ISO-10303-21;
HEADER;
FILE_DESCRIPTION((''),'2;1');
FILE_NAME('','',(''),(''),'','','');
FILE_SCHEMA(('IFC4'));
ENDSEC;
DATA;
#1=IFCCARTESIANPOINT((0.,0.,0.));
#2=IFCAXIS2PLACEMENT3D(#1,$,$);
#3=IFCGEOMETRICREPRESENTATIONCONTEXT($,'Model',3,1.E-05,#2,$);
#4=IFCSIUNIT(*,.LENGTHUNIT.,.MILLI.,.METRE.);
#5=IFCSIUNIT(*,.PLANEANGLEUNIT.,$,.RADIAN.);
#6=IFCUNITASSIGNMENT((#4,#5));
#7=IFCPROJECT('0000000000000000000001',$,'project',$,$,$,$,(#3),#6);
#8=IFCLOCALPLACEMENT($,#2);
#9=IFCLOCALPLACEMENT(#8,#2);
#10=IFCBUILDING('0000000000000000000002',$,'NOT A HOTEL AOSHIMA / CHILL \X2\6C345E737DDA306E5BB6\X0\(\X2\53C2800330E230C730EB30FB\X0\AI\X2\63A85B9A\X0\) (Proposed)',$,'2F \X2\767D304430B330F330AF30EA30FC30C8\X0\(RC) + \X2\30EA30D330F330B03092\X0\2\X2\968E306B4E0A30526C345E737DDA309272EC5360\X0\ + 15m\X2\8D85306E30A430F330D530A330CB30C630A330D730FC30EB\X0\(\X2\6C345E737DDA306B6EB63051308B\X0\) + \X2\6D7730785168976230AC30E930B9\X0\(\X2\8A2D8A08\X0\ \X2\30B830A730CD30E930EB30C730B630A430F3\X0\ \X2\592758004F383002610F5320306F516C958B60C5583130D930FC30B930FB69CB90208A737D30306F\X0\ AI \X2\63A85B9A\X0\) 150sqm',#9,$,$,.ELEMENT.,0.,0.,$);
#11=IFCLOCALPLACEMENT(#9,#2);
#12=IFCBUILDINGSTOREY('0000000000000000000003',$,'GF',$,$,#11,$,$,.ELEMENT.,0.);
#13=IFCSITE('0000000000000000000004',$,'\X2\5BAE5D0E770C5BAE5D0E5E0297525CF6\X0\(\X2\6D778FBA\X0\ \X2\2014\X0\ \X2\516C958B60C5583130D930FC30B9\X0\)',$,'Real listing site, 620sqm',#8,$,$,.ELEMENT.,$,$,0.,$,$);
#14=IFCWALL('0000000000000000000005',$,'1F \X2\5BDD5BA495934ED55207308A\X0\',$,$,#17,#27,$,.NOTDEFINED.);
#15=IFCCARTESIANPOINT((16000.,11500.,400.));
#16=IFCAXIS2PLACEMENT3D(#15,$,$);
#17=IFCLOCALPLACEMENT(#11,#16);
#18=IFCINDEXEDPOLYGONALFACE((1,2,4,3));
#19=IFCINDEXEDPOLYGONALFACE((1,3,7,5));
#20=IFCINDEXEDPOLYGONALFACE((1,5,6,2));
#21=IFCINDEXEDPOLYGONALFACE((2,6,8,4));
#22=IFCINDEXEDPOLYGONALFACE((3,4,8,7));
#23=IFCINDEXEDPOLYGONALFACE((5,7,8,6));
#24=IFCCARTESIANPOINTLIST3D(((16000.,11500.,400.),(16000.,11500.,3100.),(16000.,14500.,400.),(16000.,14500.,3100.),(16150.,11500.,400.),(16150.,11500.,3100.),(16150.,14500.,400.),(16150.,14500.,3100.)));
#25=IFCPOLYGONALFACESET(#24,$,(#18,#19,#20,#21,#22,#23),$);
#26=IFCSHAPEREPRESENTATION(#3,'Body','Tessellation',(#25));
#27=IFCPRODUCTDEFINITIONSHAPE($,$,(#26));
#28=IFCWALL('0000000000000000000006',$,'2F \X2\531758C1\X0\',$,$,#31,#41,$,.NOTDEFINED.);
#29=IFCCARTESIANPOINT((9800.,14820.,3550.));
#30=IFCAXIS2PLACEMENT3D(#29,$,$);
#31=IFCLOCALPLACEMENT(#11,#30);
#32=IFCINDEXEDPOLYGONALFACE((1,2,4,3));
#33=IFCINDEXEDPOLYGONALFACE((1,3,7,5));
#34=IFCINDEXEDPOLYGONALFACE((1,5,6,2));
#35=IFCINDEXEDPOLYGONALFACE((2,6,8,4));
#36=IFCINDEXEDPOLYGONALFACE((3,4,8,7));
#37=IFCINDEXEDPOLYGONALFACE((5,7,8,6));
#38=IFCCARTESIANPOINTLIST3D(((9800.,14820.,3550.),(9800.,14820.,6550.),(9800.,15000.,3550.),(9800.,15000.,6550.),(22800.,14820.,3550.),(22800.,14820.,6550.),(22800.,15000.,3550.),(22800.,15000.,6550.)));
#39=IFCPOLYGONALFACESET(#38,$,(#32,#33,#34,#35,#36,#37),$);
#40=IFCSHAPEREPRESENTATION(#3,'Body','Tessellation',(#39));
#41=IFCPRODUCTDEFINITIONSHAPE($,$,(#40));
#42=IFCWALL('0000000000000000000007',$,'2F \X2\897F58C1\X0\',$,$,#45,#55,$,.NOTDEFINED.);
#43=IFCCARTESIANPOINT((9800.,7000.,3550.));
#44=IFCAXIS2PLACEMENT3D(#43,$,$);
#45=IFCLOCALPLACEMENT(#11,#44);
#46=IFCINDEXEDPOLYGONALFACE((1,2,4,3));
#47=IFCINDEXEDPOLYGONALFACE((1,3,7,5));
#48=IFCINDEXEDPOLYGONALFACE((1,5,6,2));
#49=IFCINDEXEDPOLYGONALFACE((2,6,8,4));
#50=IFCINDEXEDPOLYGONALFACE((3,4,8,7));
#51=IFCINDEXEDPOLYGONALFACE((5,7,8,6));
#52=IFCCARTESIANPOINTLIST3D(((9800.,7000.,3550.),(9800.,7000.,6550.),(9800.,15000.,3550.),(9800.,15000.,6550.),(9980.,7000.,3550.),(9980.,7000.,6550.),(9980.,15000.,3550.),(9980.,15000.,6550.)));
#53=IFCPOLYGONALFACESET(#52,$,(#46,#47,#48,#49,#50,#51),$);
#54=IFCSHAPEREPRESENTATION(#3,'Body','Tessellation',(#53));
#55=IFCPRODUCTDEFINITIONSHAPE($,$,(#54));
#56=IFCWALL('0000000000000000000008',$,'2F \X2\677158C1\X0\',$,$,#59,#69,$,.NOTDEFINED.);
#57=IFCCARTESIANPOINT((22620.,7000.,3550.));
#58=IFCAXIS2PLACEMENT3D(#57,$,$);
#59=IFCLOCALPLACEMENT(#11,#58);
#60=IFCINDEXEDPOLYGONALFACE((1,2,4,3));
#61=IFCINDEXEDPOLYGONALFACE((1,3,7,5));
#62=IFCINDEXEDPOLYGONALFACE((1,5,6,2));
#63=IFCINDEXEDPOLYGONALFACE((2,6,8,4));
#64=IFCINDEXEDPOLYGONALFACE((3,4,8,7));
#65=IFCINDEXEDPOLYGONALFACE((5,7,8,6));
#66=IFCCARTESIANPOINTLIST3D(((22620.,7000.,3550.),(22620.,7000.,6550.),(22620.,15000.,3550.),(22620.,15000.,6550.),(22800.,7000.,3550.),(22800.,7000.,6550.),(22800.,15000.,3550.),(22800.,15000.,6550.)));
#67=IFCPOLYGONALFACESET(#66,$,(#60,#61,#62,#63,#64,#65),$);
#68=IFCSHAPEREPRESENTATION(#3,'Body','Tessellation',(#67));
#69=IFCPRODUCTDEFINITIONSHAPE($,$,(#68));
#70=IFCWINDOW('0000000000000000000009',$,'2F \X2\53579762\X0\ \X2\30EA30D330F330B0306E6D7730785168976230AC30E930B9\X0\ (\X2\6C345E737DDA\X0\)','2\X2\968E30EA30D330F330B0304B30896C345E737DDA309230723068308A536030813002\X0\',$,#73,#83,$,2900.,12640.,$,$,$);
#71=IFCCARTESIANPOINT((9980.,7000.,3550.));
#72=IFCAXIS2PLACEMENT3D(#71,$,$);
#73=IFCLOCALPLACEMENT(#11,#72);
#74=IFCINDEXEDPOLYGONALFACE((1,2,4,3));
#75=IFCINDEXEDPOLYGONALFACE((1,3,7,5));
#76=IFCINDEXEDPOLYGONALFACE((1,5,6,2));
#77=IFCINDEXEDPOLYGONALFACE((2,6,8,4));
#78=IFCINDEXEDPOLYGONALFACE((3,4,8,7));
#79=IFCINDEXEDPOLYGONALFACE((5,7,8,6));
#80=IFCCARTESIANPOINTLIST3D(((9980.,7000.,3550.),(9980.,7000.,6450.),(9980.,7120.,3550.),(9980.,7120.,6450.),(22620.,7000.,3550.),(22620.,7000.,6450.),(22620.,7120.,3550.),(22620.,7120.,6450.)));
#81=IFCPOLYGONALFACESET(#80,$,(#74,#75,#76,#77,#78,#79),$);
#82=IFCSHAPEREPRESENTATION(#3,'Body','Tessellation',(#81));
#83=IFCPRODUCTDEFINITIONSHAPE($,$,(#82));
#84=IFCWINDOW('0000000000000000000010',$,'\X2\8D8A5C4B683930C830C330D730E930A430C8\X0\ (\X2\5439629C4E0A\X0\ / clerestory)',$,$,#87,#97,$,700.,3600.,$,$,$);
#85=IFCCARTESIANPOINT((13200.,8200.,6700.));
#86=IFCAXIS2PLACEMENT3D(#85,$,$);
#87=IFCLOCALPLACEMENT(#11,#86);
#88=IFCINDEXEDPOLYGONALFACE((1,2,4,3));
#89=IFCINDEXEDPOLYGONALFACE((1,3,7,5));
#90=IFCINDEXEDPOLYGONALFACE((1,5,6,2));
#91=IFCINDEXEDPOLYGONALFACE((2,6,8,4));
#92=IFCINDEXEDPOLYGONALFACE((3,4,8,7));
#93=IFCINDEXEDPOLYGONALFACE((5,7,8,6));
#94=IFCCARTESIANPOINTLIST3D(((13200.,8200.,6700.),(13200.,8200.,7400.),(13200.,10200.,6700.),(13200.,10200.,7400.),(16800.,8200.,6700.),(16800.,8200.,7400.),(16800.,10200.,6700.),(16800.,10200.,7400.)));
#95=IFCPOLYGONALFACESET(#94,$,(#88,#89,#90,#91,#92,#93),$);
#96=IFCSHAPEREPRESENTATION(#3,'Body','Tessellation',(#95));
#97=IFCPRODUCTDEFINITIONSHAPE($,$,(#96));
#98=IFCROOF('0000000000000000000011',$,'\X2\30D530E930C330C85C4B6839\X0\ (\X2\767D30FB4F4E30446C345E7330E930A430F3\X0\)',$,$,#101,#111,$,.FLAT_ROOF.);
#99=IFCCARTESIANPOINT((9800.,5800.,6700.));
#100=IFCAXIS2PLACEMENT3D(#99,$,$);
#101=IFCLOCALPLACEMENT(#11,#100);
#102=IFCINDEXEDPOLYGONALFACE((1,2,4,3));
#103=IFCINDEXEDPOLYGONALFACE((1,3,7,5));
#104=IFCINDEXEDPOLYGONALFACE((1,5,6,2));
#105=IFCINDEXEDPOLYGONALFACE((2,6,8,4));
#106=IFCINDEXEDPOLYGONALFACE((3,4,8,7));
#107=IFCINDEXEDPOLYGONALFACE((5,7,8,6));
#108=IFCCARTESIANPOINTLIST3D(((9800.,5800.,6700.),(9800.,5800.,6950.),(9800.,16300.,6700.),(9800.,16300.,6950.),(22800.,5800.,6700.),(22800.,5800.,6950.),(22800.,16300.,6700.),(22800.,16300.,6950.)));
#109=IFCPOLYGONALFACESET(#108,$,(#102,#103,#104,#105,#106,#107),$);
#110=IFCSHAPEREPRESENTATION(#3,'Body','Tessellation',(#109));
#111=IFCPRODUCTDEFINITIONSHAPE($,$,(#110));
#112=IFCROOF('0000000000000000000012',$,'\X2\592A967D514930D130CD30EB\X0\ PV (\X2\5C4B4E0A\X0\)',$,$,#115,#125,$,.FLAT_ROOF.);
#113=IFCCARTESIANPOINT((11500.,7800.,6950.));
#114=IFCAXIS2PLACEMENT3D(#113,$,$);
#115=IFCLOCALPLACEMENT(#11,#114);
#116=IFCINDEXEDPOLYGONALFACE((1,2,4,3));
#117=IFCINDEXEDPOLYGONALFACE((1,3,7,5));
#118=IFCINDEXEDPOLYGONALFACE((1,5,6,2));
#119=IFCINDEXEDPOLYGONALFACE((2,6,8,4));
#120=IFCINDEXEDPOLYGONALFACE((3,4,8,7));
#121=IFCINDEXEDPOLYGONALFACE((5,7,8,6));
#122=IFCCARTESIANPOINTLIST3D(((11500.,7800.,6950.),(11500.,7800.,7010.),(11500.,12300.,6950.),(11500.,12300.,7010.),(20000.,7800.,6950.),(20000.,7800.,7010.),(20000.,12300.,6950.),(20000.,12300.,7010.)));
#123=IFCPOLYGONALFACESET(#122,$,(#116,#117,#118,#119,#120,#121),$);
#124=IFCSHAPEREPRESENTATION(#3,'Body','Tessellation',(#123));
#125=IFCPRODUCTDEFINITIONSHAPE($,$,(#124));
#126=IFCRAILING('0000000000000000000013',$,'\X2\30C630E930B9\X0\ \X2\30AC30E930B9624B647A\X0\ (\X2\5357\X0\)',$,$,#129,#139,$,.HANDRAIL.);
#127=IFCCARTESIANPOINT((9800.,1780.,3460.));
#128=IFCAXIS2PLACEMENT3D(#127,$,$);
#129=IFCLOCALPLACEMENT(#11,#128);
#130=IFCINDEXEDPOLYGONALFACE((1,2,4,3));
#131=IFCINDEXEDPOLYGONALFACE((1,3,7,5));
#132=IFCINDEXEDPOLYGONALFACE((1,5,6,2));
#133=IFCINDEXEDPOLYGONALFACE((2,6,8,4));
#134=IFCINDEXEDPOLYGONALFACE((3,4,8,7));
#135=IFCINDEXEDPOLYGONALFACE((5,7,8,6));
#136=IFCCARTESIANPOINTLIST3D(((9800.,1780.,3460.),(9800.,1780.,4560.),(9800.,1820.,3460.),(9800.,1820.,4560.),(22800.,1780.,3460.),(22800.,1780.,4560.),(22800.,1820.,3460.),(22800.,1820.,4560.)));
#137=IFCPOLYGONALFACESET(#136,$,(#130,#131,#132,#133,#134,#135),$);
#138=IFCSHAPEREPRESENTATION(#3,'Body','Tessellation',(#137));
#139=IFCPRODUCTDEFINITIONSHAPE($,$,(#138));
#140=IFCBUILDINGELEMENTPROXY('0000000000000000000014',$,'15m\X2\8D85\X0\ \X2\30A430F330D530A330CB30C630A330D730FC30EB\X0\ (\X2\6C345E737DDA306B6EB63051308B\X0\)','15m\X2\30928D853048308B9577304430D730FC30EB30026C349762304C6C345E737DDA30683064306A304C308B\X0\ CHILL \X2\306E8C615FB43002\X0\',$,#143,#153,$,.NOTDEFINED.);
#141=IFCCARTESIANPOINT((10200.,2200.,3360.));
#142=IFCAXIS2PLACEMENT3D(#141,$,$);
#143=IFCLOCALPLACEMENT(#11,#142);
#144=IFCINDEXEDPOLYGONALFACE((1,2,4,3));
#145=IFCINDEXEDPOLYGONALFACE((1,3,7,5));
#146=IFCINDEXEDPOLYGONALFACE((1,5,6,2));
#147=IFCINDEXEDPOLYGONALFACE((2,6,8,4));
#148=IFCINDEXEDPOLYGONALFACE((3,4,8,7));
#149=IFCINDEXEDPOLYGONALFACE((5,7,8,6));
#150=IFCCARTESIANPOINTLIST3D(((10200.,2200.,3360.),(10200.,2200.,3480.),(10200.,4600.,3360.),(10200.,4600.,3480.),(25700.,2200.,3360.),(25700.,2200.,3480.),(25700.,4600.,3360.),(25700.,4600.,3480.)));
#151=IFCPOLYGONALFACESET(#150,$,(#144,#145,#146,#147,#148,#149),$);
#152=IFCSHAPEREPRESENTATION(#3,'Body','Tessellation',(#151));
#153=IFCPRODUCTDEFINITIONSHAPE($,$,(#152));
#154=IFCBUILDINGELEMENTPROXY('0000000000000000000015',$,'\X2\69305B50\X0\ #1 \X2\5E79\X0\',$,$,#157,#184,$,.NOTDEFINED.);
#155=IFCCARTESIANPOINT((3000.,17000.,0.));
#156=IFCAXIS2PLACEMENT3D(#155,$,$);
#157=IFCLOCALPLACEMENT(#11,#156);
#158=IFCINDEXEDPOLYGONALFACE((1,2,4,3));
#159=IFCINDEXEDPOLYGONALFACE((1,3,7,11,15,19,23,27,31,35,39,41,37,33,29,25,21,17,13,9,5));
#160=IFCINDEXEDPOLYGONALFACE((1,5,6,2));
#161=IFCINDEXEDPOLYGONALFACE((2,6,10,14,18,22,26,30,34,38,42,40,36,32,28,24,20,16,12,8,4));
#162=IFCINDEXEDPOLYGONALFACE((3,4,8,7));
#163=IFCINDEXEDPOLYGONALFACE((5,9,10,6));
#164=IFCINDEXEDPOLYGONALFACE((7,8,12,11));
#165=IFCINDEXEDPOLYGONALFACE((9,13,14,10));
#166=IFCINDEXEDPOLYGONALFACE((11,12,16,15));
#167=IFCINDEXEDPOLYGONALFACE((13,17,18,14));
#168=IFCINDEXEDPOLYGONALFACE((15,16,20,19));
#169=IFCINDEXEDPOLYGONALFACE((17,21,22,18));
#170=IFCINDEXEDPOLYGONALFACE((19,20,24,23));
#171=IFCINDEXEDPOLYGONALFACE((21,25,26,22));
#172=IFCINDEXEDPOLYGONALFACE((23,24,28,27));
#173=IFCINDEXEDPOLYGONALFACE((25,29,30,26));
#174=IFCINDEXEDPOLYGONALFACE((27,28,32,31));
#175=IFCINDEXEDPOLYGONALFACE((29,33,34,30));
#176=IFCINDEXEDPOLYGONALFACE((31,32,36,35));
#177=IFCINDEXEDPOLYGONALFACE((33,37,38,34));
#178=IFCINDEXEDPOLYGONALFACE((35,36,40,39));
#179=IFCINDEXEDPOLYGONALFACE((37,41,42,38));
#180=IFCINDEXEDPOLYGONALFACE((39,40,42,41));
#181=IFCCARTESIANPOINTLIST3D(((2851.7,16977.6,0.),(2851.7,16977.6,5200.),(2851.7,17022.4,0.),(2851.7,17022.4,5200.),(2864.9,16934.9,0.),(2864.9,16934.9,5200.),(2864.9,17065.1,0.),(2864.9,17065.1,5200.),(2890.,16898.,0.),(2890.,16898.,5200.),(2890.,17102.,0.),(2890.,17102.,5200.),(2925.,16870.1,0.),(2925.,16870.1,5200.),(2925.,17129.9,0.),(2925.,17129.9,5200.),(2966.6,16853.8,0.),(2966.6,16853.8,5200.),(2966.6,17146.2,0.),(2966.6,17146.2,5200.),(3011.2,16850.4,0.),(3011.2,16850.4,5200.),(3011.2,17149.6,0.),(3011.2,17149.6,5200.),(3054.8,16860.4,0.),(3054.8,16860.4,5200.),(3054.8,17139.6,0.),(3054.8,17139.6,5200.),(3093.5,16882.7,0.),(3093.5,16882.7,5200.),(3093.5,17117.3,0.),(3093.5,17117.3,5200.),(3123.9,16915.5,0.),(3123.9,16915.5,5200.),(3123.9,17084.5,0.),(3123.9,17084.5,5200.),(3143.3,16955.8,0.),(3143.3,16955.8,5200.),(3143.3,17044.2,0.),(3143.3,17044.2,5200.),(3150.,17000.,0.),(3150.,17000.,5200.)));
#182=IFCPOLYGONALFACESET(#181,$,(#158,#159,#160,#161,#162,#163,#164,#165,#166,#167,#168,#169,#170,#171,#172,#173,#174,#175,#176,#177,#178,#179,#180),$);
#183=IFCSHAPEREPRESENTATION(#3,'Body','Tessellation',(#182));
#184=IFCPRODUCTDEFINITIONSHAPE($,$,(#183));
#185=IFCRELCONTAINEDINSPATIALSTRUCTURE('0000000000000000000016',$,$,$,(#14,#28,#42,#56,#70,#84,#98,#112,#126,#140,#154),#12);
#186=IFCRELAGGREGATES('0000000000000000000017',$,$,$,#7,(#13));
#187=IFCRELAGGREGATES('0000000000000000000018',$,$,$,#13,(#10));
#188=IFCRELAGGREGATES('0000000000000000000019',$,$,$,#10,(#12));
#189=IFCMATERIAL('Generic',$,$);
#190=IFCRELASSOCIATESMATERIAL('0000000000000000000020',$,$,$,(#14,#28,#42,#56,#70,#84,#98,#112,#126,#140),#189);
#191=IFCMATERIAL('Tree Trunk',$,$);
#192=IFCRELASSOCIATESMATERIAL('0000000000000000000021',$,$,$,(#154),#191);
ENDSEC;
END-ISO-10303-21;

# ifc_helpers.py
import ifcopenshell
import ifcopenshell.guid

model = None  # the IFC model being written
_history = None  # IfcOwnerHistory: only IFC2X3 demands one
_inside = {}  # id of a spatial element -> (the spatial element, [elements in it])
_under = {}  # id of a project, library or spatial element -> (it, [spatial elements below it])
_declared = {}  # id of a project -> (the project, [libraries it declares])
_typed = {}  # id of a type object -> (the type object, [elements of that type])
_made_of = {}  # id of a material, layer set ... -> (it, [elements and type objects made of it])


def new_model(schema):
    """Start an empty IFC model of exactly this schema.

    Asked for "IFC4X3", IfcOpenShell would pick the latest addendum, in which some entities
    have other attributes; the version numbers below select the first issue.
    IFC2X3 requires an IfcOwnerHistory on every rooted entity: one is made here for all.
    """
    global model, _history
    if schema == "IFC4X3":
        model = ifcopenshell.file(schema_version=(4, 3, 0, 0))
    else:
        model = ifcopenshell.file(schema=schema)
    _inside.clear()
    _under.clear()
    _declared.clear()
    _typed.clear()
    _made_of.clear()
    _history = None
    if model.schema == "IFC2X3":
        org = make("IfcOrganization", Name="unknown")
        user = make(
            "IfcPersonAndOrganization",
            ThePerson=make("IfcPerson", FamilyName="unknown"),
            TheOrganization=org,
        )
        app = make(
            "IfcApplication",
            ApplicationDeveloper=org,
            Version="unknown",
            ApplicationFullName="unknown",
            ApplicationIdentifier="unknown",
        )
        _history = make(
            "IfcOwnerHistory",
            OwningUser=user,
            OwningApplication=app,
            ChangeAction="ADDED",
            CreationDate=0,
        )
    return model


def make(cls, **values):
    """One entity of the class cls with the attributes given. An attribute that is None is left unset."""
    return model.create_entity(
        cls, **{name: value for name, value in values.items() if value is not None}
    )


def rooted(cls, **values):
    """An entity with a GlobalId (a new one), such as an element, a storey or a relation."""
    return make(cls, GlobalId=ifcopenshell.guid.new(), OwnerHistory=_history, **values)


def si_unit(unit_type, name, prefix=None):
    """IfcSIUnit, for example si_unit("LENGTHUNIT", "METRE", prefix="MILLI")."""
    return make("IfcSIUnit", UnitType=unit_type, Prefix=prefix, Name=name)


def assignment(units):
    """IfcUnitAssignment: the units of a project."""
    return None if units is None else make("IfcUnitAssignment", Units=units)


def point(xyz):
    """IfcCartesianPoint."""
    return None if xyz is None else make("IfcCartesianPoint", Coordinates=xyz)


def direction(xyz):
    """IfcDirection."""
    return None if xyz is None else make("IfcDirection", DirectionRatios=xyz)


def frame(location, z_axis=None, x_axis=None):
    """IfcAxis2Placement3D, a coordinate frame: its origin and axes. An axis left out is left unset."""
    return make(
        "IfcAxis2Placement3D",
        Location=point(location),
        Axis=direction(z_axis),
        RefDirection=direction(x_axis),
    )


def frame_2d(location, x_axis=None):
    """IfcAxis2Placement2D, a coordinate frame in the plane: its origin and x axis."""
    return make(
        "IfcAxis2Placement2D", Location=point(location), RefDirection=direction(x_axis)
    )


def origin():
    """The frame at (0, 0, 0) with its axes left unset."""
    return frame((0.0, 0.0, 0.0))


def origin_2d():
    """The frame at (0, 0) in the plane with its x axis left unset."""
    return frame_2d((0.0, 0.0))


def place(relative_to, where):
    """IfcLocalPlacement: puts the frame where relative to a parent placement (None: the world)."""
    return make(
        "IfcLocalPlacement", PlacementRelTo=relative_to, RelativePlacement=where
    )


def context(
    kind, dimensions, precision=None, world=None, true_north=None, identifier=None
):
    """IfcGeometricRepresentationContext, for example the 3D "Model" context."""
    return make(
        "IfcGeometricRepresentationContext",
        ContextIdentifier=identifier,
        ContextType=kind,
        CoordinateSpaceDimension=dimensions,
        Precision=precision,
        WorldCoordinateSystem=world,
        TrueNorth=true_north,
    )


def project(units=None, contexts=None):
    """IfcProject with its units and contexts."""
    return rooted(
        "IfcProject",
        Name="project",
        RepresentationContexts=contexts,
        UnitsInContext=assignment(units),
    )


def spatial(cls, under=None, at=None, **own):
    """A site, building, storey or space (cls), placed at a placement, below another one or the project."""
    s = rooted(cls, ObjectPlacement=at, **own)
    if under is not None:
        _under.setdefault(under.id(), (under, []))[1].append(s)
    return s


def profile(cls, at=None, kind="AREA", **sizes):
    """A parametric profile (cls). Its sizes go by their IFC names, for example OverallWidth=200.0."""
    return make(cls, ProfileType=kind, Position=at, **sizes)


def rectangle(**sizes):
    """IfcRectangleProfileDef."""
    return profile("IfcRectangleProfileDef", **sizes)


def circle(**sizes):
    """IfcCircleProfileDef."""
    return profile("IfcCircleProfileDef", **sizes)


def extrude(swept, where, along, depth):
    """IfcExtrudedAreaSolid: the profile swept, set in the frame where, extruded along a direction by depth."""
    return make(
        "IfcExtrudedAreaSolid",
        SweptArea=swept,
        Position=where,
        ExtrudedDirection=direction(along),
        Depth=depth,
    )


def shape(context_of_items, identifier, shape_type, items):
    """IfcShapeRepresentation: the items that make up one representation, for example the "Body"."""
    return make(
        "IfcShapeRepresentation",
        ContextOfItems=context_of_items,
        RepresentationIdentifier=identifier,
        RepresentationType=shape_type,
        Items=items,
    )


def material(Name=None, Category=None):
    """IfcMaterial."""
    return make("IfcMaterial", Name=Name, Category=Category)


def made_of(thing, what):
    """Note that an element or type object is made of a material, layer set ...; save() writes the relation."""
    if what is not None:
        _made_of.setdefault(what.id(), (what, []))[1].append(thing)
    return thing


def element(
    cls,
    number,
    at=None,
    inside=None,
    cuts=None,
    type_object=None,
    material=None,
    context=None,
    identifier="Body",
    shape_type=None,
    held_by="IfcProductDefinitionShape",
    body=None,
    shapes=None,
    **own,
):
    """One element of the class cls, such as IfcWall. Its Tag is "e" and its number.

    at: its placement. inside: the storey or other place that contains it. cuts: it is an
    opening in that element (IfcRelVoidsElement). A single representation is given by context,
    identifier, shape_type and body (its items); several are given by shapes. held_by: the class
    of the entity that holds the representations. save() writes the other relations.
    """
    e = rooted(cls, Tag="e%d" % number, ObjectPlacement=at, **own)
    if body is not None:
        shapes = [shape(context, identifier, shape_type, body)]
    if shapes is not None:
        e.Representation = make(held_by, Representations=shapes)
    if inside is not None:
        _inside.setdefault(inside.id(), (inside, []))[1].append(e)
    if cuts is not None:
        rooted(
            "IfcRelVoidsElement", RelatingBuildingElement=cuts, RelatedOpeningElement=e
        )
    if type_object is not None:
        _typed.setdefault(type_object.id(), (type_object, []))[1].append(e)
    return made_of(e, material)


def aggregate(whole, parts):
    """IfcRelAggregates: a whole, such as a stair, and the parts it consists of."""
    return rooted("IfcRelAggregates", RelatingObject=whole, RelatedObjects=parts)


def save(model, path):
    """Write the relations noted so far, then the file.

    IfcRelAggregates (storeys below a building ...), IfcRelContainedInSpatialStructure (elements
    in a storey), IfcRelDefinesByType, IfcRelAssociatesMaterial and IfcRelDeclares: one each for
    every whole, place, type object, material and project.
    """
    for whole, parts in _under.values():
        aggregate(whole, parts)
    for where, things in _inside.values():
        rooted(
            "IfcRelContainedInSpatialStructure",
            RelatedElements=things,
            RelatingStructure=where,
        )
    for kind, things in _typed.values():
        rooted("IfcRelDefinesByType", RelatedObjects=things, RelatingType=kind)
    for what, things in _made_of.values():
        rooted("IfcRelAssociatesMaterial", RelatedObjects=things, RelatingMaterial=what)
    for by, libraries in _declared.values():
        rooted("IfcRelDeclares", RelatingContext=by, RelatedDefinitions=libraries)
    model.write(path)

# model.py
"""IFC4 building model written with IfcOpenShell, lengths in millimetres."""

from ifc_helpers import new_model, si_unit, frame, frame_2d, origin, origin_2d, place, context, project, spatial, rectangle, circle, extrude, material, element, save


model = new_model("IFC4")

# Units and contexts
model_context = context("Model", 3, precision=1e-05, world=origin())
ifc_project = project(units=[si_unit("LENGTHUNIT", "METRE", prefix="MILLI"), si_unit("PLANEANGLEUNIT", "RADIAN")], contexts=[model_context])

# Site, building, storey
site_placement = place(None, origin())
site = spatial("IfcSite", under=ifc_project, at=site_placement, Name="宮崎県宮崎市青島(海辺 — 公開情報ベース)", ObjectType="Real listing site, 620sqm", CompositionType="ELEMENT", RefElevation=0.0)
building_placement = place(site_placement, origin())
building = spatial("IfcBuilding", under=site, at=building_placement, Name="NOT A HOTEL AOSHIMA / CHILL 水平線の家(参考モデル・AI推定) (Proposed)", ObjectType="2F 白いコンクリート(RC) + リビングを2階に上げ水平線を独占 + 15m超のインフィニティプール(水平線に溶ける) + 海へ全面ガラス(設計 ジェネラルデザイン 大堀伸。意匠は公開情報ベース・構造詳細は AI 推定) 150sqm", CompositionType="ELEMENT", ElevationOfRefHeight=0.0, ElevationOfTerrain=0.0)
storey_placement = place(building_placement, origin())
storey = spatial("IfcBuildingStorey", under=building, at=storey_placement, Name="GF", CompositionType="ELEMENT", Elevation=0.0)

# Shared definitions
ifc_material_1 = material(Name="Generic")

# Walls
wall_1_placement = place(storey_placement, frame((16000.0, 11500.0, 400.0)))
element("IfcWall", 1, at=wall_1_placement, inside=storey, material=ifc_material_1, Name="1F 寝室間仕切り", PredefinedType="NOTDEFINED", context=model_context, shape_type="SweptSolid", body=[
    extrude(rectangle(XDim=150.0, YDim=3000.0, at=frame_2d((75.0, 1500.0))), frame((16000.0, 11500.0, 400.0)), (0.0, 0.0, 1.0), 2700.0),
])
wall_2_placement = place(storey_placement, frame((9800.0, 14820.0, 3550.0)))
element("IfcWall", 2, at=wall_2_placement, inside=storey, material=ifc_material_1, Name="2F 北壁", PredefinedType="NOTDEFINED", context=model_context, shape_type="SweptSolid", body=[
    extrude(rectangle(XDim=13000.0, YDim=180.0, at=frame_2d((6500.0, 90.0))), frame((9800.0, 14820.0, 3550.0)), (0.0, 0.0, 1.0), 3000.0),
])
wall_3_placement = place(storey_placement, frame((9800.0, 7000.0, 3550.0)))
element("IfcWall", 3, at=wall_3_placement, inside=storey, material=ifc_material_1, Name="2F 西壁", PredefinedType="NOTDEFINED", context=model_context, shape_type="SweptSolid", body=[
    extrude(rectangle(XDim=180.0, YDim=8000.0, at=frame_2d((90.0, 4000.0))), frame((9800.0, 7000.0, 3550.0)), (0.0, 0.0, 1.0), 3000.0),
])
wall_4_placement = place(storey_placement, frame((22620.0, 7000.0, 3550.0)))
element("IfcWall", 4, at=wall_4_placement, inside=storey, material=ifc_material_1, Name="2F 東壁", PredefinedType="NOTDEFINED", context=model_context, shape_type="SweptSolid", body=[
    extrude(rectangle(XDim=180.0, YDim=8000.0, at=frame_2d((90.0, 4000.0))), frame((22620.0, 7000.0, 3550.0)), (0.0, 0.0, 1.0), 3000.0),
])

# Windows
window_1_placement = place(storey_placement, frame((9980.0, 7000.0, 3550.0)))
element("IfcWindow", 5, at=window_1_placement, inside=storey, material=ifc_material_1, Name="2F 南面 リビングの海へ全面ガラス (水平線)", Description="2階リビングから水平線をひとり占め。", OverallHeight=2900.0, OverallWidth=12640.0, context=model_context, shape_type="SweptSolid", body=[
    extrude(rectangle(XDim=12640.0, YDim=120.0, at=frame_2d((6320.0, 60.0))), frame((9980.0, 7000.0, 3550.0)), (0.0, 0.0, 1.0), 2900.0),
])
window_2_placement = place(storey_placement, frame((13200.0, 8200.0, 6700.0)))
element("IfcWindow", 6, at=window_2_placement, inside=storey, material=ifc_material_1, Name="越屋根トップライト (吹抜上 / clerestory)", OverallHeight=700.0, OverallWidth=3600.0, context=model_context, shape_type="SweptSolid", body=[
    extrude(rectangle(XDim=3600.0, YDim=2000.0, at=frame_2d((1800.0, 1000.0))), frame((13200.0, 8200.0, 6700.0)), (0.0, 0.0, 1.0), 700.0),
])

# Roofs
roof_1_placement = place(storey_placement, frame((9800.0, 5800.0, 6700.0)))
element("IfcRoof", 7, at=roof_1_placement, inside=storey, material=ifc_material_1, Name="フラット屋根 (白・低い水平ライン)", PredefinedType="FLAT_ROOF", context=model_context, shape_type="SweptSolid", body=[
    extrude(rectangle(XDim=13000.0, YDim=10500.0, at=frame_2d((6500.0, 5250.0))), frame((9800.0, 5800.0, 6700.0)), (0.0, 0.0, 1.0), 250.0),
])
roof_2_placement = place(storey_placement, frame((11500.0, 7800.0, 6950.0)))
element("IfcRoof", 8, at=roof_2_placement, inside=storey, material=ifc_material_1, Name="太陽光パネル PV (屋上)", PredefinedType="FLAT_ROOF", context=model_context, shape_type="SweptSolid", body=[
    extrude(rectangle(XDim=8500.0, YDim=4500.0, at=frame_2d((4250.0, 2250.0))), frame((11500.0, 7800.0, 6950.0)), (0.0, 0.0, 1.0), 60.0),
])

# Railing
railing_placement = place(storey_placement, frame((9800.0, 1780.0, 3460.0)))
element("IfcRailing", 9, at=railing_placement, inside=storey, material=ifc_material_1, Name="テラス ガラス手摺 (南)", PredefinedType="HANDRAIL", context=model_context, shape_type="SweptSolid", body=[
    extrude(rectangle(XDim=13000.0, YDim=40.0, at=frame_2d((6500.0, 20.0))), frame((9800.0, 1780.0, 3460.0)), (0.0, 0.0, 1.0), 1100.0),
])

# Building element proxies
proxy_1_placement = place(storey_placement, frame((10200.0, 2200.0, 3360.0)))
element("IfcBuildingElementProxy", 10, at=proxy_1_placement, inside=storey, material=ifc_material_1, Name="15m超 インフィニティプール (水平線に溶ける)", Description="15mを超える長いプール。水面が水平線とつながる CHILL の象徴。", PredefinedType="NOTDEFINED", context=model_context, shape_type="SweptSolid", body=[
    extrude(rectangle(XDim=15500.0, YDim=2400.0, at=frame_2d((7750.0, 1200.0))), frame((10200.0, 2200.0, 3360.0)), (0.0, 0.0, 1.0), 120.0),
])
ifc_material_2 = material(Name="Tree Trunk")
proxy_2_placement = place(storey_placement, frame((3000.0, 17000.0, 0.0)))
element("IfcBuildingElementProxy", 11, at=proxy_2_placement, inside=storey, material=ifc_material_2, Name="椰子 #1 幹", PredefinedType="NOTDEFINED", context=model_context, shape_type="SweptSolid", body=[
    extrude(circle(Radius=150.0, at=origin_2d()), frame((3000.0, 17000.0, 0.0)), (0.0, 0.0, 1.0), 5200.0),
])

save(model, "model.ifc")
